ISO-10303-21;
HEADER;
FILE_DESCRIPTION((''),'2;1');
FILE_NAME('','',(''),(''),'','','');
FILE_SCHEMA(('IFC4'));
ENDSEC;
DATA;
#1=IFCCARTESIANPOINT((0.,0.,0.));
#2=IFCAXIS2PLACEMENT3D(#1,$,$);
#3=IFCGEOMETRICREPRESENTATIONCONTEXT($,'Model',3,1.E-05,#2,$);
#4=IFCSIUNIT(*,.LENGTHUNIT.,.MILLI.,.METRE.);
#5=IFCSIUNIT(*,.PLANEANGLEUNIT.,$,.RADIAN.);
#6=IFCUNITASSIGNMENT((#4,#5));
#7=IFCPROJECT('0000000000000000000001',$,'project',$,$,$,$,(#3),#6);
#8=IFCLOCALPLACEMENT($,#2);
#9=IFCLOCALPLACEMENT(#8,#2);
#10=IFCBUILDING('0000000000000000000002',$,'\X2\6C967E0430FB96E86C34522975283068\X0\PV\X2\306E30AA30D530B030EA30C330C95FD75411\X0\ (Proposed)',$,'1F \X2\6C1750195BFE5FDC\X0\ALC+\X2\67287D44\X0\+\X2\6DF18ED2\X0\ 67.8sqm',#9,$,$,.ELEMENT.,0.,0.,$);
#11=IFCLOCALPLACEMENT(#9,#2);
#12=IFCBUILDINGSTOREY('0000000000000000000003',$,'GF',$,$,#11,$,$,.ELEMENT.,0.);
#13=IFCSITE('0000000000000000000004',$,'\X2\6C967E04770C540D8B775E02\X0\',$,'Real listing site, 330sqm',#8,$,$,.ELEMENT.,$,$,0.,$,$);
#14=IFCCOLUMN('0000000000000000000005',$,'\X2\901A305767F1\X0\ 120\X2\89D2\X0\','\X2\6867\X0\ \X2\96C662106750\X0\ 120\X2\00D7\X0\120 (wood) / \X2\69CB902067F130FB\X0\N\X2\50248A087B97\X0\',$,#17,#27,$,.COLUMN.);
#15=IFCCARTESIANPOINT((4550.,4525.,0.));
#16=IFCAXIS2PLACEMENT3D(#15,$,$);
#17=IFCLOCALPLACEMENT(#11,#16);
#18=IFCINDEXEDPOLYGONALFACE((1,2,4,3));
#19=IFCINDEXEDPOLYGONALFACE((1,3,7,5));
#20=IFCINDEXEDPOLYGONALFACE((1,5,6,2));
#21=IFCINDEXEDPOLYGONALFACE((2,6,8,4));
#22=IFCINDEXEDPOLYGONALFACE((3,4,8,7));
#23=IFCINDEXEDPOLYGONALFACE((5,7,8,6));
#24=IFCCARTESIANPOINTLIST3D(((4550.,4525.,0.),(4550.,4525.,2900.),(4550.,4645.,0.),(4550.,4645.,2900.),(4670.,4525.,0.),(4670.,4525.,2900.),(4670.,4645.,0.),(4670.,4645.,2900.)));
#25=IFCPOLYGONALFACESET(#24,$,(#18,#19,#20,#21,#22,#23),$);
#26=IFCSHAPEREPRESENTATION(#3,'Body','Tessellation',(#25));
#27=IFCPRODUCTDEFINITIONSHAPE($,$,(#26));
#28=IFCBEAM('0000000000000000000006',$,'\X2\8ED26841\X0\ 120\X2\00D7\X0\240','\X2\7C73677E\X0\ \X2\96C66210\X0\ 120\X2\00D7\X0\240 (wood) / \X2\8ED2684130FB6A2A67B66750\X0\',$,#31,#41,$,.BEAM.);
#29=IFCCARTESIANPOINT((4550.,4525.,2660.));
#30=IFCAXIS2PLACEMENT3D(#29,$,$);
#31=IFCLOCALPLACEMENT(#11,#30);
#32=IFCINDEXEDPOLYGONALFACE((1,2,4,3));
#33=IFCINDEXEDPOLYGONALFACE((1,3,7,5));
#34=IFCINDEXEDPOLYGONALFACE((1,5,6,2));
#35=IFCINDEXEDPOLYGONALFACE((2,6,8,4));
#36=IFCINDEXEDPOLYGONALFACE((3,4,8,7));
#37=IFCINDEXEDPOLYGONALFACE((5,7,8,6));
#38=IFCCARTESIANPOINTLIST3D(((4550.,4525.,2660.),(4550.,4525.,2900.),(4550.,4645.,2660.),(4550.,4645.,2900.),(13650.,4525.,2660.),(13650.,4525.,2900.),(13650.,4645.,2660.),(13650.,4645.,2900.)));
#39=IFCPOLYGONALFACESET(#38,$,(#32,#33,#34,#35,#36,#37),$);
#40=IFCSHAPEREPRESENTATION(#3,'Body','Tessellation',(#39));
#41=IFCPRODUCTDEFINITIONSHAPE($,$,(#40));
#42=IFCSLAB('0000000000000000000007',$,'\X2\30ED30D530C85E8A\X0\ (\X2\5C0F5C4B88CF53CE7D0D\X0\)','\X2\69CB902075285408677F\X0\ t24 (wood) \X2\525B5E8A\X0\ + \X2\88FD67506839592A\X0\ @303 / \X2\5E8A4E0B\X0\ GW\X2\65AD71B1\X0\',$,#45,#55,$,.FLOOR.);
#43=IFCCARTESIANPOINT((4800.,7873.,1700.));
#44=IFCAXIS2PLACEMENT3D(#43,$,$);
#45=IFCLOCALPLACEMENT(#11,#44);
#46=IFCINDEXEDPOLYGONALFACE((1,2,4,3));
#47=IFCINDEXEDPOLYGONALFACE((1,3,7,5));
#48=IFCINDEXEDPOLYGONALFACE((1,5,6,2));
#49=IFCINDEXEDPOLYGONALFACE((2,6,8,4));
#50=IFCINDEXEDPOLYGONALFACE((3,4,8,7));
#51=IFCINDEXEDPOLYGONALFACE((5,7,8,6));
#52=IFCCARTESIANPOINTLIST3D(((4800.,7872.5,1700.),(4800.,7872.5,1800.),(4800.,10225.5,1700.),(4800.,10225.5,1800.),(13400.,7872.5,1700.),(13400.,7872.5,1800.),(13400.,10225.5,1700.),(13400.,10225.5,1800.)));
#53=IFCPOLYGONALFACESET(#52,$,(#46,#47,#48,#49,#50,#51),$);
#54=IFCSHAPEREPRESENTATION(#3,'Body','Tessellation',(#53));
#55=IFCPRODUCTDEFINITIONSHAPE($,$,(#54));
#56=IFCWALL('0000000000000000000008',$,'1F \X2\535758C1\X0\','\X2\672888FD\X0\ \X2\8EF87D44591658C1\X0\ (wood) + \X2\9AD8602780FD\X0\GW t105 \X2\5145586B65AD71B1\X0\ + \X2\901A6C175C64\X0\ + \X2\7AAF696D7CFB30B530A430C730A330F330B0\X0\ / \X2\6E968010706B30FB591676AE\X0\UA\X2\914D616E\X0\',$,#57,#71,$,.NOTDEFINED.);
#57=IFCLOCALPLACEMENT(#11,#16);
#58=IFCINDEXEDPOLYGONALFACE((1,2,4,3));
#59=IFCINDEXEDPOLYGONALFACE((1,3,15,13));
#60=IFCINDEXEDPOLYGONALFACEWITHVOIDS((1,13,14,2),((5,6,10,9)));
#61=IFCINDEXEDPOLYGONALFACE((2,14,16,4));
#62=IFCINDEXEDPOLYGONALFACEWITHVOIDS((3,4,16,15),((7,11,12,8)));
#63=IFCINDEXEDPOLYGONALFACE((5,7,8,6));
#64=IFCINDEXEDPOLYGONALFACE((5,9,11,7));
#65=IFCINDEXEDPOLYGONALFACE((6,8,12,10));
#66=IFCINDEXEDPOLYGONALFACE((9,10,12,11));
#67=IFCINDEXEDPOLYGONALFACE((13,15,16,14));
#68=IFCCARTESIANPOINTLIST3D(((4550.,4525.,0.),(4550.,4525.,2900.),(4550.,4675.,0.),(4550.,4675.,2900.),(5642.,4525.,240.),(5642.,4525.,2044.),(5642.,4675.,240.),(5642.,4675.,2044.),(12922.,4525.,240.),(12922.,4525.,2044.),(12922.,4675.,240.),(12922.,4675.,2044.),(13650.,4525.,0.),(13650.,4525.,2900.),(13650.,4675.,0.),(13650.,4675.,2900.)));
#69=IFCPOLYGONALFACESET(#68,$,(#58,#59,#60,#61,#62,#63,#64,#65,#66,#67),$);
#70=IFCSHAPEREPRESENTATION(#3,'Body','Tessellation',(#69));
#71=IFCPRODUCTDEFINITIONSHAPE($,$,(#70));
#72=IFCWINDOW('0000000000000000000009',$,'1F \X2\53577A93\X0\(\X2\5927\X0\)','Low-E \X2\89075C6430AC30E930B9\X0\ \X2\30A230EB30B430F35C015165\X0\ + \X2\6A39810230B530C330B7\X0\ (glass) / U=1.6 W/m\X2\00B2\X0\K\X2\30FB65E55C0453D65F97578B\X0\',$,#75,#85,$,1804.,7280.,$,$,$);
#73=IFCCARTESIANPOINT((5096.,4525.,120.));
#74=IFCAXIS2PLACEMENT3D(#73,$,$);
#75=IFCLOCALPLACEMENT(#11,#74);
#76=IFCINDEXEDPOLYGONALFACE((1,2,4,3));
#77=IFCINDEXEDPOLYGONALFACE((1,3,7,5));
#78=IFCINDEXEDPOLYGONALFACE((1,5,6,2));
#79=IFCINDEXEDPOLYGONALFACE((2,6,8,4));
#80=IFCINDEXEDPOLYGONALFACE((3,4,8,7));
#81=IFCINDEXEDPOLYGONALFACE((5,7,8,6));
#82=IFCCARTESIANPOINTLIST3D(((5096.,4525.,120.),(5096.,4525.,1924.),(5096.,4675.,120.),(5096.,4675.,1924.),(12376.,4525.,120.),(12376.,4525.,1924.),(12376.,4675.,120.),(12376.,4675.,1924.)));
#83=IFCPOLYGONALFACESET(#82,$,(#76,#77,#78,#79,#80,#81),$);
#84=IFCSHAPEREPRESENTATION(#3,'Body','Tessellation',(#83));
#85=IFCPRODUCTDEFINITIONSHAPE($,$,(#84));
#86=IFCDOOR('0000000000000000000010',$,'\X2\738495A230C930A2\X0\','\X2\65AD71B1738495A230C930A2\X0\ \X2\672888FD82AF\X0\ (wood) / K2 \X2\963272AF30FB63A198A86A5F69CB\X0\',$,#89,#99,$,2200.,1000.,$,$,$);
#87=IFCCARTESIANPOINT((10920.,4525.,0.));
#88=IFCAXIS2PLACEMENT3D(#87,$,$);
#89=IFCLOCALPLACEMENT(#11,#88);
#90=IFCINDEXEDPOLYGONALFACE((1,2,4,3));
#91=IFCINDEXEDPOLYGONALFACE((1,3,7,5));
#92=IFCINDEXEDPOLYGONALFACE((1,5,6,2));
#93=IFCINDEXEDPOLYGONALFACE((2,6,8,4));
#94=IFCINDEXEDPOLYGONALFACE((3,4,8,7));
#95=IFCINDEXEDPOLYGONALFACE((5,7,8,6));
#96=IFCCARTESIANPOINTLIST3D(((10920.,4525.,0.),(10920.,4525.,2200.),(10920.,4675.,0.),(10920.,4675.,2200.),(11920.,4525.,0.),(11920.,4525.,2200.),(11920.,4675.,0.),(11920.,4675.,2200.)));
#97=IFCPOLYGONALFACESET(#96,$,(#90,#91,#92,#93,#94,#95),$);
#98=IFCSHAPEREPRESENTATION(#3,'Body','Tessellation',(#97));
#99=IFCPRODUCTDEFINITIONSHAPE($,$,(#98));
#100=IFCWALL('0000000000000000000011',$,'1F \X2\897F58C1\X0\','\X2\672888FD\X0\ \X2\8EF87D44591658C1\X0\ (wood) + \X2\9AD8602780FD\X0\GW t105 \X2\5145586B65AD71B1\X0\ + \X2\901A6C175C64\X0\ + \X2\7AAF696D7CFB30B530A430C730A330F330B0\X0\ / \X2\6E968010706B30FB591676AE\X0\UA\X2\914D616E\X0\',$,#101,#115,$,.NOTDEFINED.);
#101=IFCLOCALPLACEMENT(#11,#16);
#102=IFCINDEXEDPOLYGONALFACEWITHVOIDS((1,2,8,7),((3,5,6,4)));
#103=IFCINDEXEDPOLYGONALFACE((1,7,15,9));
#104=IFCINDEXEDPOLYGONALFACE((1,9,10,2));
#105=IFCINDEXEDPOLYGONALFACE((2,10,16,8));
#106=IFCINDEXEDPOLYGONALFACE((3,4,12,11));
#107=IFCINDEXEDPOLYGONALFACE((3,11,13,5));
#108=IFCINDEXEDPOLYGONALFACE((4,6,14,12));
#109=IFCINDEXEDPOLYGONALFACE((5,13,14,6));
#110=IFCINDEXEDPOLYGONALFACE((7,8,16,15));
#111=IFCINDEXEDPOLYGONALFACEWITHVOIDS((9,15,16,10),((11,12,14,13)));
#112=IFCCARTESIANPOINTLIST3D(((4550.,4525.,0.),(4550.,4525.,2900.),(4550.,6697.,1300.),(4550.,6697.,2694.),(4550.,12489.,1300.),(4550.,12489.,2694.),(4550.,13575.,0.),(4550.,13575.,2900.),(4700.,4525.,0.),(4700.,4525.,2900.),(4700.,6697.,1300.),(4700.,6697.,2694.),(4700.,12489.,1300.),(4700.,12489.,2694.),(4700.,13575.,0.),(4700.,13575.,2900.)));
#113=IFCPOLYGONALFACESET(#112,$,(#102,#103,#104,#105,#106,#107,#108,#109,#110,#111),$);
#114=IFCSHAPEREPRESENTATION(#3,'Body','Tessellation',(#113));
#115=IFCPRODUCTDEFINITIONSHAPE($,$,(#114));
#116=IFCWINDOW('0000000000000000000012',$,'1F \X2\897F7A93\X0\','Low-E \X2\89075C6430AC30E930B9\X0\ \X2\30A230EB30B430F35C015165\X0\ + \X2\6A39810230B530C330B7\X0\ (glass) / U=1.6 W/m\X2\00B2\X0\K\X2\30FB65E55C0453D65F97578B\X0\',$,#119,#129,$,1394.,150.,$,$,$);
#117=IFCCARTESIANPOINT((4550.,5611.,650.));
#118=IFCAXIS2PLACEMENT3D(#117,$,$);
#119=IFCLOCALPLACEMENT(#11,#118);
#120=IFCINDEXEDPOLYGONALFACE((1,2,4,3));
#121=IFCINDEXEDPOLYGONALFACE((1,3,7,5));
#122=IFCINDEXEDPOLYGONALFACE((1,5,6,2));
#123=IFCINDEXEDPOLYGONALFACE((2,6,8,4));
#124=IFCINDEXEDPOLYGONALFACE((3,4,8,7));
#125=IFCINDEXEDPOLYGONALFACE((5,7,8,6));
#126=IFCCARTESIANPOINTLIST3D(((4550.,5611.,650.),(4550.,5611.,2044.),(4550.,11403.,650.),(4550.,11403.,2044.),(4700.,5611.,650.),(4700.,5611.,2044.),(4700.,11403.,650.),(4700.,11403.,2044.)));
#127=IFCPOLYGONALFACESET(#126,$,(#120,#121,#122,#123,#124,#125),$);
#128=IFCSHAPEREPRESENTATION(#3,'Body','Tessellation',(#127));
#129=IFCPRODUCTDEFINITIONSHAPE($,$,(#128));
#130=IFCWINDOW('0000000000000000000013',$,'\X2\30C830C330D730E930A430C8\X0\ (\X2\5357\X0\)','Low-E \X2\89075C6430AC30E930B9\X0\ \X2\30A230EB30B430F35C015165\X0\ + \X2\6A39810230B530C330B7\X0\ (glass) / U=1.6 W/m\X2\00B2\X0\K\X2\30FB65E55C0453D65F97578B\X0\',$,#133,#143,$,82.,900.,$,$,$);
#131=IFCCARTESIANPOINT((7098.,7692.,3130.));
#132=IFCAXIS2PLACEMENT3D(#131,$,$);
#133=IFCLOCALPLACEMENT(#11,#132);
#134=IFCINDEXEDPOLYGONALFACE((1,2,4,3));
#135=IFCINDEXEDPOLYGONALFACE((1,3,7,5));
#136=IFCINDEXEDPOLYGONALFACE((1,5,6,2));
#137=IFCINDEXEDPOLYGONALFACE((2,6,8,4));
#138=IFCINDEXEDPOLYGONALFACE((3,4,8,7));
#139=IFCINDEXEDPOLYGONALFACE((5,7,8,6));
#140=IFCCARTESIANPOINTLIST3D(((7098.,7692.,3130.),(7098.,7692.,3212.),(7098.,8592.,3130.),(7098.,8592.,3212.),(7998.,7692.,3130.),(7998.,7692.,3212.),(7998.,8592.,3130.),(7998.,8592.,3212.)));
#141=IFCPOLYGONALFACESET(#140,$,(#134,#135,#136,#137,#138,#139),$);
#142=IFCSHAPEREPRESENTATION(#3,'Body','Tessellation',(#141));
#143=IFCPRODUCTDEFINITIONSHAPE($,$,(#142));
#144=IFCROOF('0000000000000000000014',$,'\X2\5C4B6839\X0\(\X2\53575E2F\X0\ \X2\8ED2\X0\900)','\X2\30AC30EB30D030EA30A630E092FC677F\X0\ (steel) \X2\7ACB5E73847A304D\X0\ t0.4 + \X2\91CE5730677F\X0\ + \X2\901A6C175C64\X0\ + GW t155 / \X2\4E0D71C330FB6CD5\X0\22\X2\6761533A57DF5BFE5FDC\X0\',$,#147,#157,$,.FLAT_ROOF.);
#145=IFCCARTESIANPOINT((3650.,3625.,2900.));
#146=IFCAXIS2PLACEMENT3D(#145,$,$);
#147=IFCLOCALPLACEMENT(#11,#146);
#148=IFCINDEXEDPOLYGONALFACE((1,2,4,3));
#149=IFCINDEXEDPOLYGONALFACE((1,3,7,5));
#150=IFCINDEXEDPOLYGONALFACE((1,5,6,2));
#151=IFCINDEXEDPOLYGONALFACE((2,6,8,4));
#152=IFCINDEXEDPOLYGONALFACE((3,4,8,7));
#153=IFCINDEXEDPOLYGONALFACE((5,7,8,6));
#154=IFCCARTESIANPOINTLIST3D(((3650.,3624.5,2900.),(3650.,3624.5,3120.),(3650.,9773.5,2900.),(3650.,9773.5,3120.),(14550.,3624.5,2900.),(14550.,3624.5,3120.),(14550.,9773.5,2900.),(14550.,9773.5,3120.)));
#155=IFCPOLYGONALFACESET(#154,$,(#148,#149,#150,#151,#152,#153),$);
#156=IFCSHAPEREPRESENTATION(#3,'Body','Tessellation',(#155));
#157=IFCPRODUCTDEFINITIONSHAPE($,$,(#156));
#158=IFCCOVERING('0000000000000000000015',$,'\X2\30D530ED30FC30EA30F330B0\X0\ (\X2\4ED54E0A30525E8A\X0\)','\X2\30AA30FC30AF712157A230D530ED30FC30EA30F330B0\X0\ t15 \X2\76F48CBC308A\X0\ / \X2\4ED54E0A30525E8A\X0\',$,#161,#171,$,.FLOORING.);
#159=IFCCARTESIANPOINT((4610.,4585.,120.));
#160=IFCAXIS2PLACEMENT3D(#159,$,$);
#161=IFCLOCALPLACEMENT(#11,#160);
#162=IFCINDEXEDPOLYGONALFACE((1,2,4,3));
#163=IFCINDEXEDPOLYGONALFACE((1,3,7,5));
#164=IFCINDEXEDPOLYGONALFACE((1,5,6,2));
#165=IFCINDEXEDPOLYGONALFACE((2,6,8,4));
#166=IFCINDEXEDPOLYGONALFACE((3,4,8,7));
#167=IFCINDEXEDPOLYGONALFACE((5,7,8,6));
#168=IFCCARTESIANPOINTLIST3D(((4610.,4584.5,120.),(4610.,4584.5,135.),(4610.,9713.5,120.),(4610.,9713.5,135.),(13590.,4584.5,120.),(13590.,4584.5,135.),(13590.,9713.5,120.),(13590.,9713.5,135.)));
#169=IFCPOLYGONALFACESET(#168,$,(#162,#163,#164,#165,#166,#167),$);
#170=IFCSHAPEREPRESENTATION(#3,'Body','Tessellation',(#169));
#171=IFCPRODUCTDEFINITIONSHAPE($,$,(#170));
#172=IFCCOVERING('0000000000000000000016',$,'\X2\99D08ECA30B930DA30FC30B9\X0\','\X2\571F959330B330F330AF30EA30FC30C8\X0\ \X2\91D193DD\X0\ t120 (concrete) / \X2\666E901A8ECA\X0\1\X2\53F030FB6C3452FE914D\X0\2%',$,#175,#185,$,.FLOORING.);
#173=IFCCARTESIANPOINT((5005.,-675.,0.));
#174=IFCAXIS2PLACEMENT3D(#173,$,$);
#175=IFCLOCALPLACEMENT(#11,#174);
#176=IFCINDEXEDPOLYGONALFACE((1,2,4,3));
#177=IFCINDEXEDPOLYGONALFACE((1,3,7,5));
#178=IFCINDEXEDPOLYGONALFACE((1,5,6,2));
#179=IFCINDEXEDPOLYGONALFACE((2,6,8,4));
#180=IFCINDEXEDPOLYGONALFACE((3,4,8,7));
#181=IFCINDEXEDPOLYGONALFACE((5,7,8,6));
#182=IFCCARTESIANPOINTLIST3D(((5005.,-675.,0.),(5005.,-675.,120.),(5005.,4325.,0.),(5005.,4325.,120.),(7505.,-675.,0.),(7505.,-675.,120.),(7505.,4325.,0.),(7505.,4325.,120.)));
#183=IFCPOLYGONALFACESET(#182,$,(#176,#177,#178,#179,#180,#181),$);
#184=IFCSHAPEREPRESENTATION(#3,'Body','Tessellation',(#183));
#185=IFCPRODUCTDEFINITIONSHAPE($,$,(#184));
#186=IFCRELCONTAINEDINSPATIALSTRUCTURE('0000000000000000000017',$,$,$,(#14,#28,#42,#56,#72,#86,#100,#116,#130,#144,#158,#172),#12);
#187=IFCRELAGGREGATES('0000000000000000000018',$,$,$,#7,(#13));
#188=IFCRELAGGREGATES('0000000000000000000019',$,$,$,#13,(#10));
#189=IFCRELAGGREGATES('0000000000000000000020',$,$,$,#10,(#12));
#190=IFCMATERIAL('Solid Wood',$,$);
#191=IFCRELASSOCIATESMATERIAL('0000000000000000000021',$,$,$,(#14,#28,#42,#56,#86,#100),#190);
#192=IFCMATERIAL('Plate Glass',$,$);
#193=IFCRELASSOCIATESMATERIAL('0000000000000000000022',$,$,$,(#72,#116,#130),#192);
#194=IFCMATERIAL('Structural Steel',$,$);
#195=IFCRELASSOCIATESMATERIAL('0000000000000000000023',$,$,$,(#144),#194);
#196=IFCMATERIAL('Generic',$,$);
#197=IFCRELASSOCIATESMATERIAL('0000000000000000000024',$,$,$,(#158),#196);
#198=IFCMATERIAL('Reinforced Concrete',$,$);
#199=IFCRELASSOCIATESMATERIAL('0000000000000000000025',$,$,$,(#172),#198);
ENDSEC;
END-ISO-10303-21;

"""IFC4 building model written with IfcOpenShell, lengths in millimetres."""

from ifc_helpers import new_model, si_unit, frame, frame_2d, origin, place, context, project, spatial, rectangle, extrude, material, element, fill, save


model = new_model("IFC4")

# Units and contexts
model_context = context("Model", 3, precision=1e-05, world=origin())
ifc_project = project(units=[si_unit("LENGTHUNIT", "METRE", prefix="MILLI"), si_unit("PLANEANGLEUNIT", "RADIAN")], contexts=[model_context])

# Site, building, storey
site_placement = place(None, origin())
site = spatial("IfcSite", under=ifc_project, at=site_placement, Name="沖縄県名護市", ObjectType="Real listing site, 330sqm", CompositionType="ELEMENT", RefElevation=0.0)
building_placement = place(site_placement, origin())
building = spatial("IfcBuilding", under=site, at=building_placement, Name="沖縄・雨水利用とPVのオフグリッド志向 (Proposed)", ObjectType="1F 気候対応ALC+木組+深軒 67.8sqm", CompositionType="ELEMENT", ElevationOfRefHeight=0.0, ElevationOfTerrain=0.0)
storey_placement = place(building_placement, origin())
storey = spatial("IfcBuildingStorey", under=building, at=storey_placement, Name="GF", CompositionType="ELEMENT", Elevation=0.0)

# Column
ifc_material_1 = material(Name="Solid Wood")
column_1_placement = place(storey_placement, frame((4550.0, 4525.0, 0.0)))
element("IfcColumn", 1, at=column_1_placement, inside=storey, material=ifc_material_1, Name="通し柱 120角", Description="桧 集成材 120×120 (wood) / 構造柱・N値計算", PredefinedType="COLUMN", context=model_context, shape_type="SweptSolid", body=[
    extrude(rectangle(XDim=120.0, YDim=120.0, at=frame_2d((60.0, 60.0))), frame((4550.0, 4525.0, 0.0)), (0.0, 0.0, 1.0), 2900.0),
])

# Beam
beam_1_placement = place(storey_placement, frame((4550.0, 4525.0, 2660.0)))
element("IfcBeam", 2, at=beam_1_placement, inside=storey, material=ifc_material_1, Name="軒桁 120×240", Description="米松 集成 120×240 (wood) / 軒桁・横架材", PredefinedType="BEAM", context=model_context, shape_type="SweptSolid", body=[
    extrude(rectangle(XDim=9100.0, YDim=120.0, at=frame_2d((4550.0, 60.0))), frame((4550.0, 4525.0, 2660.0)), (0.0, 0.0, 1.0), 240.0),
])

# Slab
ifc_material_2 = material(Name="Reinforced Concrete")
slab_1_placement = place(storey_placement, frame((4800.0, 7873.0, 1700.0)))
element("IfcSlab", 3, at=slab_1_placement, inside=storey, material=ifc_material_1, Name="ロフト床 (小屋裏収納)", Description="構造用合板 t24 (wood) 剛床 + 製材根太 @303 / 床下 GW断熱", PredefinedType="FLOOR", context=model_context, shape_type="SweptSolid", body=[
    extrude(rectangle(XDim=8600.0, YDim=2353.0, at=frame_2d((4300.0, 1176.0))), frame((4800.0, 7873.0, 1700.0)), (0.0, 0.0, 1.0), 100.0),
])

# Wall, openings, window, door
wall_1_placement = place(storey_placement, frame((4550.0, 4525.0, 0.0)))
wall_1 = element("IfcWall", 4, at=wall_1_placement, inside=storey, material=ifc_material_1, Name="1F 南壁", Description="木製 軸組外壁 (wood) + 高性能GW t105 充填断熱 + 通気層 + 窯業系サイディング / 準耐火・外皮UA配慮", PredefinedType="NOTDEFINED", context=model_context, shape_type="SweptSolid", body=[
    extrude(rectangle(XDim=9100.0, YDim=150.0, at=frame_2d((4550.0, 75.0))), frame((4550.0, 4525.0, 0.0)), (0.0, 0.0, 1.0), 2900.0),
])
opening_1_placement = place(storey_placement, frame((5096.0, 4525.0, 120.0)))
opening_1 = element("IfcOpeningElement", 5, at=opening_1_placement, cuts=wall_1, PredefinedType="NOTDEFINED", context=model_context, shape_type="SweptSolid", body=[
    extrude(rectangle(XDim=7280.0, YDim=150.0, at=frame_2d((3640.0, 75.0))), frame((5096.0, 4525.0, 120.0)), (0.0, 0.0, 1.0), 1804.0),
])
opening_2_placement = place(storey_placement, frame((10920.0, 4525.0, 0.0)))
opening_2 = element("IfcOpeningElement", 6, at=opening_2_placement, cuts=wall_1, PredefinedType="NOTDEFINED", context=model_context, shape_type="SweptSolid", body=[
    extrude(rectangle(XDim=1000.0, YDim=150.0, at=frame_2d((500.0, 75.0))), frame((10920.0, 4525.0, 0.0)), (0.0, 0.0, 1.0), 2200.0),
])
ifc_material_3 = material(Name="Plate Glass")
window_1_placement = place(storey_placement, frame((5096.0, 4525.0, 120.0)))
window_1 = element("IfcWindow", 7, at=window_1_placement, inside=storey, material=ifc_material_3, Name="1F 南窓(大)", Description="Low-E 複層ガラス アルゴン封入 + 樹脂サッシ (glass) / U=1.6 W/m²K・日射取得型", OverallHeight=1804.0, OverallWidth=7280.0, context=model_context, shape_type="SweptSolid", body=[
    extrude(rectangle(XDim=7280.0, YDim=150.0, at=frame_2d((3640.0, 75.0))), frame((5096.0, 4525.0, 120.0)), (0.0, 0.0, 1.0), 1804.0),
])
fill(opening_1, window_1)
door_1_placement = place(storey_placement, frame((10920.0, 4525.0, 0.0)))
door_1 = element("IfcDoor", 8, at=door_1_placement, inside=storey, material=ifc_material_1, Name="玄関ドア", Description="断熱玄関ドア 木製芯 (wood) / K2 防犯・採風機構", OverallHeight=2200.0, OverallWidth=1000.0, context=model_context, shape_type="SweptSolid", body=[
    extrude(rectangle(XDim=1000.0, YDim=150.0, at=frame_2d((500.0, 75.0))), frame((10920.0, 4525.0, 0.0)), (0.0, 0.0, 1.0), 2200.0),
])
fill(opening_2, door_1)

# Wall, opening, window
wall_2_placement = place(storey_placement, frame((4550.0, 4525.0, 0.0)))
wall_2 = element("IfcWall", 9, at=wall_2_placement, inside=storey, material=ifc_material_1, Name="1F 西壁", Description="木製 軸組外壁 (wood) + 高性能GW t105 充填断熱 + 通気層 + 窯業系サイディング / 準耐火・外皮UA配慮", PredefinedType="NOTDEFINED", context=model_context, shape_type="SweptSolid", body=[
    extrude(rectangle(XDim=150.0, YDim=9050.0, at=frame_2d((75.0, 4525.0))), frame((4550.0, 4525.0, 0.0)), (0.0, 0.0, 1.0), 2900.0),
])
opening_3_placement = place(storey_placement, frame((4550.0, 5611.0, 650.0)))
opening_3 = element("IfcOpeningElement", 10, at=opening_3_placement, cuts=wall_2, PredefinedType="NOTDEFINED", context=model_context, shape_type="SweptSolid", body=[
    extrude(rectangle(XDim=150.0, YDim=5792.0, at=frame_2d((75.0, 2896.0))), frame((4550.0, 5611.0, 650.0)), (0.0, 0.0, 1.0), 1394.0),
])
window_2_placement = place(storey_placement, frame((4550.0, 5611.0, 650.0)))
window_2 = element("IfcWindow", 11, at=window_2_placement, inside=storey, material=ifc_material_3, Name="1F 西窓", Description="Low-E 複層ガラス アルゴン封入 + 樹脂サッシ (glass) / U=1.6 W/m²K・日射取得型", OverallHeight=1394.0, OverallWidth=150.0, context=model_context, shape_type="SweptSolid", body=[
    extrude(rectangle(XDim=150.0, YDim=5792.0, at=frame_2d((75.0, 2896.0))), frame((4550.0, 5611.0, 650.0)), (0.0, 0.0, 1.0), 1394.0),
])
fill(opening_3, window_2)

# Window
window_3_placement = place(storey_placement, frame((7098.0, 7692.0, 3130.0)))
element("IfcWindow", 12, at=window_3_placement, inside=storey, material=ifc_material_3, Name="トップライト (南)", Description="Low-E 複層ガラス アルゴン封入 + 樹脂サッシ (glass) / U=1.6 W/m²K・日射取得型", OverallHeight=82.0, OverallWidth=900.0, context=model_context, shape_type="SweptSolid", body=[
    extrude(rectangle(XDim=900.0, YDim=900.0, at=frame_2d((450.0, 450.0))), frame((7098.0, 7692.0, 3130.0)), (0.0, 0.0, 1.0), 82.0),
])

# Roof
ifc_material_4 = material(Name="Structural Steel")
roof_placement = place(storey_placement, frame((3650.0, 3625.0, 2900.0)))
element("IfcRoof", 13, at=roof_placement, inside=storey, material=ifc_material_4, Name="屋根(南帯 軒900)", Description="ガルバリウム鋼板 (steel) 立平葺き t0.4 + 野地板 + 通気層 + GW t155 / 不燃・法22条区域対応", PredefinedType="FLAT_ROOF", context=model_context, shape_type="SweptSolid", body=[
    extrude(rectangle(XDim=10900.0, YDim=6149.0, at=frame_2d((5450.0, 3074.0))), frame((3650.0, 3625.0, 2900.0)), (0.0, 0.0, 1.0), 220.0),
])

# Coverings
ifc_material_5 = material(Name="Generic")
covering_1_placement = place(storey_placement, frame((4610.0, 4585.0, 120.0)))
element("IfcCovering", 14, at=covering_1_placement, inside=storey, material=ifc_material_5, Name="フローリング (仕上げ床)", Description="オーク無垢フローリング t15 直貼り / 仕上げ床", PredefinedType="FLOORING", context=model_context, shape_type="SweptSolid", body=[
    extrude(rectangle(XDim=8980.0, YDim=5129.0, at=frame_2d((4490.0, 2564.0))), frame((4610.0, 4585.0, 120.0)), (0.0, 0.0, 1.0), 15.0),
])
covering_2_placement = place(storey_placement, frame((5005.0, -675.0, 0.0)))
element("IfcCovering", 15, at=covering_2_placement, inside=storey, material=ifc_material_2, Name="駐車スペース", Description="土間コンクリート 金鏝 t120 (concrete) / 普通車1台・水勾配2%", PredefinedType="FLOORING", context=model_context, shape_type="SweptSolid", body=[
    extrude(rectangle(XDim=2500.0, YDim=5000.0, at=frame_2d((1250.0, 2500.0))), frame((5005.0, -675.0, 0.0)), (0.0, 0.0, 1.0), 120.0),
])

save(model, "model.ifc")
